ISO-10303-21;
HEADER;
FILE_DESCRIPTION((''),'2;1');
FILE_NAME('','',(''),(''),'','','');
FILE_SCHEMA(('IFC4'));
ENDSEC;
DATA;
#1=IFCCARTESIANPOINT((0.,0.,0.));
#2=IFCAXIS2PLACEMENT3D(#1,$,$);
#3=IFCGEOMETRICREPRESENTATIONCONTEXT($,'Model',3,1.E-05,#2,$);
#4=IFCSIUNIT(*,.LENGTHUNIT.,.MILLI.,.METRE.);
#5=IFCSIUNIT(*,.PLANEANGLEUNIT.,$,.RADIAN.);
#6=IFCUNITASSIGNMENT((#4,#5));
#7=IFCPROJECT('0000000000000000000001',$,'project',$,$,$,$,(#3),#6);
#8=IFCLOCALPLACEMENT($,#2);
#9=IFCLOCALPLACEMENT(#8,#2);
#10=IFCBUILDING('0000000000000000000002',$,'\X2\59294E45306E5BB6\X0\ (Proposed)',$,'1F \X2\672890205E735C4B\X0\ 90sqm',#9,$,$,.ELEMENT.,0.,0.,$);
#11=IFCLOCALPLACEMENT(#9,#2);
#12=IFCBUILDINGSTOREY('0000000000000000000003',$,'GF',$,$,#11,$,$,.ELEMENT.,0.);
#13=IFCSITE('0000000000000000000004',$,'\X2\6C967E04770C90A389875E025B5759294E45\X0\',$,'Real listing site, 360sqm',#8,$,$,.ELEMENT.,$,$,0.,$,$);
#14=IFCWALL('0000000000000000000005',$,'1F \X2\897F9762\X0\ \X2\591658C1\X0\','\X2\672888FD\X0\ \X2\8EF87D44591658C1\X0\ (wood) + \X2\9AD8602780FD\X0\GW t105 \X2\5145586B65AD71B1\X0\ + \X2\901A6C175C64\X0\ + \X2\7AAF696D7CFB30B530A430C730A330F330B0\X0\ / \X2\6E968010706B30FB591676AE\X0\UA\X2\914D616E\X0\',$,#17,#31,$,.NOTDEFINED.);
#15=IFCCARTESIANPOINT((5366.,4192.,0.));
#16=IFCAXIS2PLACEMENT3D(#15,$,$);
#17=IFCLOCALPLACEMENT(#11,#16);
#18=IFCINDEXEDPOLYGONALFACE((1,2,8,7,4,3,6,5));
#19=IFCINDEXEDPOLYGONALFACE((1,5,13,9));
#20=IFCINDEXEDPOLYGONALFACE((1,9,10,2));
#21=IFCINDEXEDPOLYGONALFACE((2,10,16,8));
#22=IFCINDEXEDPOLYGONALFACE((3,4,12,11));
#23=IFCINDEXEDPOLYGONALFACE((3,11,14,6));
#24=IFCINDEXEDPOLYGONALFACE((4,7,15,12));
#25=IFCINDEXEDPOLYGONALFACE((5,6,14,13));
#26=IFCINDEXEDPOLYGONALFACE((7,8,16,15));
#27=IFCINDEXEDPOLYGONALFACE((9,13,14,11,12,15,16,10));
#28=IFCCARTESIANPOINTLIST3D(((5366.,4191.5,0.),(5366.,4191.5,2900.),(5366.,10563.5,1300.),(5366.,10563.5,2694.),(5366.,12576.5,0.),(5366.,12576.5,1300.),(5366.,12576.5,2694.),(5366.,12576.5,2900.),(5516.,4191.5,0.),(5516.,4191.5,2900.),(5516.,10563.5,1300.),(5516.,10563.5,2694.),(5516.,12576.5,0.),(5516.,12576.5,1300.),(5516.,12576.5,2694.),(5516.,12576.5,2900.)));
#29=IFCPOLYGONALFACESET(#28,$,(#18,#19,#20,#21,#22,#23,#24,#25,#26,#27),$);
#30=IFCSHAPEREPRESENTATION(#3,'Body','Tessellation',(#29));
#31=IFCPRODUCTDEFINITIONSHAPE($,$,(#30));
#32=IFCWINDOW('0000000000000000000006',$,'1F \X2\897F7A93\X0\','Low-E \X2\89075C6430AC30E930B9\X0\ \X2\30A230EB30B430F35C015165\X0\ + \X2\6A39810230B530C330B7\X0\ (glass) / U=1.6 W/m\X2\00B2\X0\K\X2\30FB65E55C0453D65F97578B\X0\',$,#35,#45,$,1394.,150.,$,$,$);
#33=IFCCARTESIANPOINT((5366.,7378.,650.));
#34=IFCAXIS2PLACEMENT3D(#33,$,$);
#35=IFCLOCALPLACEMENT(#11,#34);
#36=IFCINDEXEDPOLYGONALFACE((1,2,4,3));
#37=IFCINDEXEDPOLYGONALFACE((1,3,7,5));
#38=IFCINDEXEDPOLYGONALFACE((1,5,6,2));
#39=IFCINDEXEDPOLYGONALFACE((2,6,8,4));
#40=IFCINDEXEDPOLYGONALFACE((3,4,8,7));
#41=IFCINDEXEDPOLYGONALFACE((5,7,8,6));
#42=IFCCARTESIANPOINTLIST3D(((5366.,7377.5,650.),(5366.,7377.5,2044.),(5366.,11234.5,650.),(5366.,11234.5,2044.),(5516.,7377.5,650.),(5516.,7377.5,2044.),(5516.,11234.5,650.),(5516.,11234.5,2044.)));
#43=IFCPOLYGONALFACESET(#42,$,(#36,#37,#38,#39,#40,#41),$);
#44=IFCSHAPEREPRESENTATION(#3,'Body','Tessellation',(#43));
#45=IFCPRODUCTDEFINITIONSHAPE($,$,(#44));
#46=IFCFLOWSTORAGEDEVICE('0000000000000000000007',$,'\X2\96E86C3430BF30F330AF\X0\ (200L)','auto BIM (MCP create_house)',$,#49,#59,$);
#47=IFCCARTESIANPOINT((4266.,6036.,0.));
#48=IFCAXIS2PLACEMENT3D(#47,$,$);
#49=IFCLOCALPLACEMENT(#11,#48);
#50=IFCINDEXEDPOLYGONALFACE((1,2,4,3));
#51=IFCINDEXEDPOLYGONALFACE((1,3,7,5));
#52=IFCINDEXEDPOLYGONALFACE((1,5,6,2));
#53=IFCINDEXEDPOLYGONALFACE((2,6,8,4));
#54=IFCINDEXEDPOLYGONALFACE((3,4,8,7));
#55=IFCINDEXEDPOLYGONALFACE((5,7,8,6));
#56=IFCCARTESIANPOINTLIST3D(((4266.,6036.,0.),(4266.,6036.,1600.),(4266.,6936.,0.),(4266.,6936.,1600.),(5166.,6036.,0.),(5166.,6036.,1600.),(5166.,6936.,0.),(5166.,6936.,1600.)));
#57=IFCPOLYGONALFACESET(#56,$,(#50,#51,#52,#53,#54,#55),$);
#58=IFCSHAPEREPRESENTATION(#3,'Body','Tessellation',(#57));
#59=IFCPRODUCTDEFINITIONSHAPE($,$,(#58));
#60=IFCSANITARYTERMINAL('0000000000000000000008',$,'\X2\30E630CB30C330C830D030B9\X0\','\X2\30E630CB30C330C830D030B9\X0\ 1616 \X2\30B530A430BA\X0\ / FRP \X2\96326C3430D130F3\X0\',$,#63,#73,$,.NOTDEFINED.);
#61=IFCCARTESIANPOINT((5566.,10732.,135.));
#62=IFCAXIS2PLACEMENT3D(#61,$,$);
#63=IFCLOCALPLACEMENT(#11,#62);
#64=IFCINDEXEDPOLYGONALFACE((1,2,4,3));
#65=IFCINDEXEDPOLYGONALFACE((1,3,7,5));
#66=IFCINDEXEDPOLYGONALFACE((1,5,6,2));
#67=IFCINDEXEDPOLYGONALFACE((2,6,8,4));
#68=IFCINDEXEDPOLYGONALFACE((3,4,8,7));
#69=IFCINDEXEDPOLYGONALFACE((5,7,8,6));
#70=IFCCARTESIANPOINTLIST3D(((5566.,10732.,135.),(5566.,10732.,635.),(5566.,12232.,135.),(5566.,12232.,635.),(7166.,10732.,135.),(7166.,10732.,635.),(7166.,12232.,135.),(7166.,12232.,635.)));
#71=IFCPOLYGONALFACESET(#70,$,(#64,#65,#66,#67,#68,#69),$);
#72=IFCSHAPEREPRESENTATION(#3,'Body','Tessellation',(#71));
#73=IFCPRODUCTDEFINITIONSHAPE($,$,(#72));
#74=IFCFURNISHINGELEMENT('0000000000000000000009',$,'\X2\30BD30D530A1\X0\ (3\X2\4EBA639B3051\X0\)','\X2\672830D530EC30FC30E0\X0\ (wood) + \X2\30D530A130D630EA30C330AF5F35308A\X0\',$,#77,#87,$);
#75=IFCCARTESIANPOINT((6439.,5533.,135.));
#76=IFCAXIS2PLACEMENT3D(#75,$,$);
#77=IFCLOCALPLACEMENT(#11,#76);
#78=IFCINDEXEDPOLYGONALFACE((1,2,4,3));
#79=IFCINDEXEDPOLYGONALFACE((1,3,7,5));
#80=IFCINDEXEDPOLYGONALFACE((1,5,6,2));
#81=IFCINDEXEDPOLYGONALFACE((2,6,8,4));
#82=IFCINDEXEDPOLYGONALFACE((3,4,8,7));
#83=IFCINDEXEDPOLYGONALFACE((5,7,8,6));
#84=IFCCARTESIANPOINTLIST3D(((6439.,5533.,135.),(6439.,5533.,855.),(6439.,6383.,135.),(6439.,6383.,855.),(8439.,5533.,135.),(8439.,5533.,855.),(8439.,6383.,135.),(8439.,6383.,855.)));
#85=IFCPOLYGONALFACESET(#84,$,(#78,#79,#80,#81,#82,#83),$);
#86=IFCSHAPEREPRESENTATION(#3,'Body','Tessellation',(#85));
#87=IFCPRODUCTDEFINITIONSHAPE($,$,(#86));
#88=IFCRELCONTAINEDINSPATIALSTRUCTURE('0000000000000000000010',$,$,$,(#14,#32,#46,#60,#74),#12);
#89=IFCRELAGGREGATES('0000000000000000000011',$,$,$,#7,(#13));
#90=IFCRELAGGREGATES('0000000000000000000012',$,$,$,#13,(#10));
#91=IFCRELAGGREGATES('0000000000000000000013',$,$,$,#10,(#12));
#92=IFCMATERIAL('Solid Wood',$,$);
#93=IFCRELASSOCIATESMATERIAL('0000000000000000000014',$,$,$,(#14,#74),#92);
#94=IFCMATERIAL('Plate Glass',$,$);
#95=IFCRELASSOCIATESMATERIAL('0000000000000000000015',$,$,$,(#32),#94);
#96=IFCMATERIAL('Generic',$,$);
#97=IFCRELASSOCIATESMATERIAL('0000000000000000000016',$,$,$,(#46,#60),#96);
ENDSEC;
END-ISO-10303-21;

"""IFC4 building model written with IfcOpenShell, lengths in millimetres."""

from ifc_helpers import new_model, si_unit, frame, frame_2d, origin, place, context, project, spatial, rectangle, extrude, material, element, fill, save


model = new_model("IFC4")

# Units and contexts
model_context = context("Model", 3, precision=1e-05, world=origin())
ifc_project = project(units=[si_unit("LENGTHUNIT", "METRE", prefix="MILLI"), si_unit("PLANEANGLEUNIT", "RADIAN")], contexts=[model_context])

# Site, building, storey
site_placement = place(None, origin())
site = spatial("IfcSite", under=ifc_project, at=site_placement, Name="沖縄県那覇市字天久", ObjectType="Real listing site, 360sqm", CompositionType="ELEMENT", RefElevation=0.0)
building_placement = place(site_placement, origin())
building = spatial("IfcBuilding", under=site, at=building_placement, Name="天久の家 (Proposed)", ObjectType="1F 木造平屋 90sqm", CompositionType="ELEMENT", ElevationOfRefHeight=0.0, ElevationOfTerrain=0.0)
storey_placement = place(building_placement, origin())
storey = spatial("IfcBuildingStorey", under=building, at=storey_placement, Name="GF", CompositionType="ELEMENT", Elevation=0.0)

# Shared definitions
ifc_material_1 = material(Name="Solid Wood")

# Shared definitions
ifc_material_2 = material(Name="Plate Glass")

# Wall, opening, window
wall_1_placement = place(storey_placement, frame((5366.0, 4192.0, 0.0)))
wall_1 = element("IfcWall", 1, at=wall_1_placement, inside=storey, material=ifc_material_1, Name="1F 西面 外壁", Description="木製 軸組外壁 (wood) + 高性能GW t105 充填断熱 + 通気層 + 窯業系サイディング / 準耐火・外皮UA配慮", PredefinedType="NOTDEFINED", context=model_context, shape_type="SweptSolid", body=[
    extrude(rectangle(XDim=150.0, YDim=8385.0, at=frame_2d((75.0, 4192.0))), frame((5366.0, 4192.0, 0.0)), (0.0, 0.0, 1.0), 2900.0),
])
opening_1_placement = place(storey_placement, frame((5366.0, 7378.0, 650.0)))
opening_1 = element("IfcOpeningElement", 2, at=opening_1_placement, cuts=wall_1, PredefinedType="NOTDEFINED", context=model_context, shape_type="SweptSolid", body=[
    extrude(rectangle(XDim=150.0, YDim=3857.0, at=frame_2d((75.0, 1928.0))), frame((5366.0, 7378.0, 650.0)), (0.0, 0.0, 1.0), 1394.0),
])
window_1_placement = place(storey_placement, frame((5366.0, 7378.0, 650.0)))
window_1 = element("IfcWindow", 3, at=window_1_placement, inside=storey, material=ifc_material_2, Name="1F 西窓", Description="Low-E 複層ガラス アルゴン封入 + 樹脂サッシ (glass) / U=1.6 W/m²K・日射取得型", OverallHeight=1394.0, OverallWidth=150.0, context=model_context, shape_type="SweptSolid", body=[
    extrude(rectangle(XDim=150.0, YDim=3857.0, at=frame_2d((75.0, 1928.0))), frame((5366.0, 7378.0, 650.0)), (0.0, 0.0, 1.0), 1394.0),
])
fill(opening_1, window_1)

# Shared definitions
ifc_material_3 = material(Name="Generic")

# Flow storage device
flow_storage_device_placement = place(storey_placement, frame((4266.0, 6036.0, 0.0)))
element("IfcFlowStorageDevice", 4, at=flow_storage_device_placement, inside=storey, material=ifc_material_3, Name="雨水タンク (200L)", Description="auto BIM (MCP create_house)", context=model_context, shape_type="SweptSolid", body=[
    extrude(rectangle(XDim=900.0, YDim=900.0, at=frame_2d((450.0, 450.0))), frame((4266.0, 6036.0, 0.0)), (0.0, 0.0, 1.0), 1600.0),
])

# Sanitary terminal
sanitary_terminal_placement = place(storey_placement, frame((5566.0, 10732.0, 135.0)))
element("IfcSanitaryTerminal", 5, at=sanitary_terminal_placement, inside=storey, material=ifc_material_3, Name="ユニットバス", Description="ユニットバス 1616 サイズ / FRP 防水パン", PredefinedType="NOTDEFINED", context=model_context, shape_type="SweptSolid", body=[
    extrude(rectangle(XDim=1600.0, YDim=1500.0, at=frame_2d((800.0, 750.0))), frame((5566.0, 10732.0, 135.0)), (0.0, 0.0, 1.0), 500.0),
])

# Furnishing element
furnishing_placement = place(storey_placement, frame((6439.0, 5533.0, 135.0)))
element("IfcFurnishingElement", 6, at=furnishing_placement, inside=storey, material=ifc_material_1, Name="ソファ (3人掛け)", Description="木フレーム (wood) + ファブリック張り", context=model_context, shape_type="SweptSolid", body=[
    extrude(rectangle(XDim=2000.0, YDim=850.0, at=frame_2d((1000.0, 425.0))), frame((6439.0, 5533.0, 135.0)), (0.0, 0.0, 1.0), 720.0),
])

save(model, "model.ifc")
